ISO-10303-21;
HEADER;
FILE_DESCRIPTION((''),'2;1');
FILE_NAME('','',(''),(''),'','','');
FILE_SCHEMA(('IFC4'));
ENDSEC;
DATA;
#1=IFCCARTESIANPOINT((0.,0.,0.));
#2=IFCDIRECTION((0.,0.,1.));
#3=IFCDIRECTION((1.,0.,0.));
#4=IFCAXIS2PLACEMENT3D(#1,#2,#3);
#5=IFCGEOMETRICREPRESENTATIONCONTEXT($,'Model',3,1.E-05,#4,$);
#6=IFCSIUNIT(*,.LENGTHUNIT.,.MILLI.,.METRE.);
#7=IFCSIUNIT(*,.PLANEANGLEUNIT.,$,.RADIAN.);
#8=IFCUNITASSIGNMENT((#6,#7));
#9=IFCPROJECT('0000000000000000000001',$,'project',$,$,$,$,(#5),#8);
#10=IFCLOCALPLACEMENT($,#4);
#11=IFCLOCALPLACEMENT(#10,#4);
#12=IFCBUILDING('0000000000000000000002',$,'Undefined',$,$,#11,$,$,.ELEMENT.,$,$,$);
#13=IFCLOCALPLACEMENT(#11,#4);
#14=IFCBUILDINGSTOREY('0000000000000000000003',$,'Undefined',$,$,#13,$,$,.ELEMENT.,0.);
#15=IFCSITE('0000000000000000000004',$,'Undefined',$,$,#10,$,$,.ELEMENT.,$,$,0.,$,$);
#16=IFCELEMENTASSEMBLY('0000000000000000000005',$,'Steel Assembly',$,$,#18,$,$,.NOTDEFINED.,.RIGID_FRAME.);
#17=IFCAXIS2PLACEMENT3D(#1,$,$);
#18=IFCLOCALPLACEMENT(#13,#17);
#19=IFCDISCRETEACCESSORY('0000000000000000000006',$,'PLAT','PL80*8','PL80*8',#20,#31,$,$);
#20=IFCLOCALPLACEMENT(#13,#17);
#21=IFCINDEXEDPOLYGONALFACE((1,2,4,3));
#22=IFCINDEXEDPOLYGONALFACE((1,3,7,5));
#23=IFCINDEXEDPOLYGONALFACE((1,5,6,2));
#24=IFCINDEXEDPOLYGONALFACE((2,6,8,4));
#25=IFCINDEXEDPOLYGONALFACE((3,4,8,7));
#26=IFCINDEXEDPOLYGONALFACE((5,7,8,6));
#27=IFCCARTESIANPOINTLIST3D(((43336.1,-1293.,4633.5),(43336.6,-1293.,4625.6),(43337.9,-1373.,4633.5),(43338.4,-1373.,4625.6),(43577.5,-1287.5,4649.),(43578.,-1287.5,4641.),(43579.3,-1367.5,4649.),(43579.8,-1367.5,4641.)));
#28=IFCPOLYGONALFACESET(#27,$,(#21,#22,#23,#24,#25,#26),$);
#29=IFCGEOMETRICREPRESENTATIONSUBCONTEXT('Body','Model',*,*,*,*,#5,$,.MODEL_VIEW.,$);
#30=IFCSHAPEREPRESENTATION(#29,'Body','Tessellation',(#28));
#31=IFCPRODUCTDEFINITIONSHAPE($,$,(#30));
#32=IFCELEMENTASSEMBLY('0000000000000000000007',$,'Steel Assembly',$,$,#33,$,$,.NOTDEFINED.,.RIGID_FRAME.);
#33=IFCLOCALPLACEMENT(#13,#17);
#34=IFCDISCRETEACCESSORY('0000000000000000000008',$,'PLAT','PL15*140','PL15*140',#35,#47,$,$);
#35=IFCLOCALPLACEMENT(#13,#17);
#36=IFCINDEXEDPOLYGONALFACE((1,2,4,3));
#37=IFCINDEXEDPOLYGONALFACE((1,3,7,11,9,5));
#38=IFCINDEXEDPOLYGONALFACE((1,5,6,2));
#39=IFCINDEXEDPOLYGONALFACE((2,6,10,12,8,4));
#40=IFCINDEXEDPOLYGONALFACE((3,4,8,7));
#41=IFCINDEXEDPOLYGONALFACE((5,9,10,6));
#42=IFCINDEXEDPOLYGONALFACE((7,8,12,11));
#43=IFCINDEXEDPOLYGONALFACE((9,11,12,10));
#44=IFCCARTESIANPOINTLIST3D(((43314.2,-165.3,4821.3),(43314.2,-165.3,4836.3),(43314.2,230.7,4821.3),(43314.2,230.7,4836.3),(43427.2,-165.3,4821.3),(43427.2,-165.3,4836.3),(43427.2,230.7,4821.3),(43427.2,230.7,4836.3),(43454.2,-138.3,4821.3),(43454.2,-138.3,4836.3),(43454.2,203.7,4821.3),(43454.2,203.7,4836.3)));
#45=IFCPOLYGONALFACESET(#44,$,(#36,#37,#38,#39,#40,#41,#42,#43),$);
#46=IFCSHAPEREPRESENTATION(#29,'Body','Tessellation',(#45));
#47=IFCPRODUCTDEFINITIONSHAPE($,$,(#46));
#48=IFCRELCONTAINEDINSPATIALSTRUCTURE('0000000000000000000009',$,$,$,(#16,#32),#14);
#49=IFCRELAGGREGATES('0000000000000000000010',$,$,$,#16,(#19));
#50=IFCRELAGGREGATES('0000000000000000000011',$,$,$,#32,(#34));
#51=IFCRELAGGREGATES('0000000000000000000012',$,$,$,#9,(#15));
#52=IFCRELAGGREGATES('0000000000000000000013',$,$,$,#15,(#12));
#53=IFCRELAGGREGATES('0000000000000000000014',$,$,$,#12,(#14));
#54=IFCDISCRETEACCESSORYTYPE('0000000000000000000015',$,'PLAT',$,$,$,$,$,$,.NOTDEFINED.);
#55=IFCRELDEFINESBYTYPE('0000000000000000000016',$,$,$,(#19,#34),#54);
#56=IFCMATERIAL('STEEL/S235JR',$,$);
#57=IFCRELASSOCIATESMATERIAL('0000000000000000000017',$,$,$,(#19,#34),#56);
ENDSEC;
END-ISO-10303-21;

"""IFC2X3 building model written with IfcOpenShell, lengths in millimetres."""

from ifc_helpers import new_model, si_unit, frame, origin_with_axes, place, context, subcontext, project, spatial, polyline, outline, extrude, material, type_object, element, aggregate, save


model = new_model("IFC2X3")

# Units and contexts
model_context = context("Model", 3, precision=1e-05, world=origin_with_axes())
body_context = subcontext(model_context, "Body", "Model", "MODEL_VIEW")
ifc_project = project(units=[si_unit("LENGTHUNIT", "METRE", prefix="MILLI"), si_unit("PLANEANGLEUNIT", "RADIAN")], contexts=[model_context])

# Site, building, storey
site_placement = place(None, origin_with_axes())
site = spatial("IfcSite", under=ifc_project, at=site_placement, Name="Undefined", CompositionType="ELEMENT", RefElevation=0.0)
building_placement = place(site_placement, origin_with_axes())
building = spatial("IfcBuilding", under=site, at=building_placement, Name="Undefined", CompositionType="ELEMENT")
storey_placement = place(building_placement, origin_with_axes())
storey = spatial("IfcBuildingStorey", under=building, at=storey_placement, Name="Undefined", CompositionType="ELEMENT", Elevation=0.0)

# Shared definitions
ifc_material_1 = material(Name="STEEL/S235JR")

# Element assembly
assembly_1_placement = place(storey_placement, origin_with_axes())
assembly_1 = element("IfcElementAssembly", 1, at=assembly_1_placement, inside=storey, Name="Steel Assembly", AssemblyPlace="NOTDEFINED", PredefinedType="RIGID_FRAME")

# Discrete accessory
discrete_accessory_type_1 = type_object("IfcDiscreteAccessoryType", Name="PLAT")
discrete_accessory_1_placement = place(assembly_1_placement, frame((43337.2, -1333.0, 4629.5), z_axis=(-0.063801, -0.001447, 0.997962), x_axis=(0.997704, 0.022685, 0.063817)))
discrete_accessory_1 = element("IfcDiscreteAccessory", 2, at=discrete_accessory_1_placement, type_object=discrete_accessory_type_1, material=ifc_material_1, Name="PLAT", Description="PL80*8", ObjectType="PL80*8", context=body_context, shape_type="SweptSolid", body=[
    extrude(outline(polyline([(242.0, 40.0), (242.0, -40.0), (0.0, -40.0), (0.0, 40.0), (242.0, 40.0)])), frame((0.0, 0.0, -4.0), z_axis=(0.0, 0.0, 1.0), x_axis=(1.0, 0.0, 0.0)), (0.0, 0.0, 1.0), 8.0),
])

# Element assembly, discrete accessory
assembly_2_placement = place(storey_placement, origin_with_axes())
assembly_2 = element("IfcElementAssembly", 3, at=assembly_2_placement, inside=storey, Name="Steel Assembly", AssemblyPlace="NOTDEFINED", PredefinedType="RIGID_FRAME")
discrete_accessory_2_placement = place(assembly_2_placement, frame((43314.2, 230.7, 4828.8), z_axis=(0.0, 0.0, -1.0), x_axis=(1.0, 0.0, 0.0)))
discrete_accessory_2 = element("IfcDiscreteAccessory", 4, at=discrete_accessory_2_placement, type_object=discrete_accessory_type_1, material=ifc_material_1, Name="PLAT", Description="PL15*140", ObjectType="PL15*140", context=body_context, shape_type="SweptSolid", body=[
    extrude(outline(polyline([(0.0, 0.0), (113.0, 0.0), (140.0, 27.0), (140.0, 369.0), (113.0, 396.0), (0.0, 396.0), (0.0, 0.0)])), frame((0.0, 0.0, -7.5), z_axis=(0.0, 0.0, 1.0), x_axis=(1.0, 0.0, 0.0)), (0.0, 0.0, 1.0), 15.0),
])

aggregate(assembly_1, [discrete_accessory_1])
aggregate(assembly_2, [discrete_accessory_2])

save(model, "model.ifc")
